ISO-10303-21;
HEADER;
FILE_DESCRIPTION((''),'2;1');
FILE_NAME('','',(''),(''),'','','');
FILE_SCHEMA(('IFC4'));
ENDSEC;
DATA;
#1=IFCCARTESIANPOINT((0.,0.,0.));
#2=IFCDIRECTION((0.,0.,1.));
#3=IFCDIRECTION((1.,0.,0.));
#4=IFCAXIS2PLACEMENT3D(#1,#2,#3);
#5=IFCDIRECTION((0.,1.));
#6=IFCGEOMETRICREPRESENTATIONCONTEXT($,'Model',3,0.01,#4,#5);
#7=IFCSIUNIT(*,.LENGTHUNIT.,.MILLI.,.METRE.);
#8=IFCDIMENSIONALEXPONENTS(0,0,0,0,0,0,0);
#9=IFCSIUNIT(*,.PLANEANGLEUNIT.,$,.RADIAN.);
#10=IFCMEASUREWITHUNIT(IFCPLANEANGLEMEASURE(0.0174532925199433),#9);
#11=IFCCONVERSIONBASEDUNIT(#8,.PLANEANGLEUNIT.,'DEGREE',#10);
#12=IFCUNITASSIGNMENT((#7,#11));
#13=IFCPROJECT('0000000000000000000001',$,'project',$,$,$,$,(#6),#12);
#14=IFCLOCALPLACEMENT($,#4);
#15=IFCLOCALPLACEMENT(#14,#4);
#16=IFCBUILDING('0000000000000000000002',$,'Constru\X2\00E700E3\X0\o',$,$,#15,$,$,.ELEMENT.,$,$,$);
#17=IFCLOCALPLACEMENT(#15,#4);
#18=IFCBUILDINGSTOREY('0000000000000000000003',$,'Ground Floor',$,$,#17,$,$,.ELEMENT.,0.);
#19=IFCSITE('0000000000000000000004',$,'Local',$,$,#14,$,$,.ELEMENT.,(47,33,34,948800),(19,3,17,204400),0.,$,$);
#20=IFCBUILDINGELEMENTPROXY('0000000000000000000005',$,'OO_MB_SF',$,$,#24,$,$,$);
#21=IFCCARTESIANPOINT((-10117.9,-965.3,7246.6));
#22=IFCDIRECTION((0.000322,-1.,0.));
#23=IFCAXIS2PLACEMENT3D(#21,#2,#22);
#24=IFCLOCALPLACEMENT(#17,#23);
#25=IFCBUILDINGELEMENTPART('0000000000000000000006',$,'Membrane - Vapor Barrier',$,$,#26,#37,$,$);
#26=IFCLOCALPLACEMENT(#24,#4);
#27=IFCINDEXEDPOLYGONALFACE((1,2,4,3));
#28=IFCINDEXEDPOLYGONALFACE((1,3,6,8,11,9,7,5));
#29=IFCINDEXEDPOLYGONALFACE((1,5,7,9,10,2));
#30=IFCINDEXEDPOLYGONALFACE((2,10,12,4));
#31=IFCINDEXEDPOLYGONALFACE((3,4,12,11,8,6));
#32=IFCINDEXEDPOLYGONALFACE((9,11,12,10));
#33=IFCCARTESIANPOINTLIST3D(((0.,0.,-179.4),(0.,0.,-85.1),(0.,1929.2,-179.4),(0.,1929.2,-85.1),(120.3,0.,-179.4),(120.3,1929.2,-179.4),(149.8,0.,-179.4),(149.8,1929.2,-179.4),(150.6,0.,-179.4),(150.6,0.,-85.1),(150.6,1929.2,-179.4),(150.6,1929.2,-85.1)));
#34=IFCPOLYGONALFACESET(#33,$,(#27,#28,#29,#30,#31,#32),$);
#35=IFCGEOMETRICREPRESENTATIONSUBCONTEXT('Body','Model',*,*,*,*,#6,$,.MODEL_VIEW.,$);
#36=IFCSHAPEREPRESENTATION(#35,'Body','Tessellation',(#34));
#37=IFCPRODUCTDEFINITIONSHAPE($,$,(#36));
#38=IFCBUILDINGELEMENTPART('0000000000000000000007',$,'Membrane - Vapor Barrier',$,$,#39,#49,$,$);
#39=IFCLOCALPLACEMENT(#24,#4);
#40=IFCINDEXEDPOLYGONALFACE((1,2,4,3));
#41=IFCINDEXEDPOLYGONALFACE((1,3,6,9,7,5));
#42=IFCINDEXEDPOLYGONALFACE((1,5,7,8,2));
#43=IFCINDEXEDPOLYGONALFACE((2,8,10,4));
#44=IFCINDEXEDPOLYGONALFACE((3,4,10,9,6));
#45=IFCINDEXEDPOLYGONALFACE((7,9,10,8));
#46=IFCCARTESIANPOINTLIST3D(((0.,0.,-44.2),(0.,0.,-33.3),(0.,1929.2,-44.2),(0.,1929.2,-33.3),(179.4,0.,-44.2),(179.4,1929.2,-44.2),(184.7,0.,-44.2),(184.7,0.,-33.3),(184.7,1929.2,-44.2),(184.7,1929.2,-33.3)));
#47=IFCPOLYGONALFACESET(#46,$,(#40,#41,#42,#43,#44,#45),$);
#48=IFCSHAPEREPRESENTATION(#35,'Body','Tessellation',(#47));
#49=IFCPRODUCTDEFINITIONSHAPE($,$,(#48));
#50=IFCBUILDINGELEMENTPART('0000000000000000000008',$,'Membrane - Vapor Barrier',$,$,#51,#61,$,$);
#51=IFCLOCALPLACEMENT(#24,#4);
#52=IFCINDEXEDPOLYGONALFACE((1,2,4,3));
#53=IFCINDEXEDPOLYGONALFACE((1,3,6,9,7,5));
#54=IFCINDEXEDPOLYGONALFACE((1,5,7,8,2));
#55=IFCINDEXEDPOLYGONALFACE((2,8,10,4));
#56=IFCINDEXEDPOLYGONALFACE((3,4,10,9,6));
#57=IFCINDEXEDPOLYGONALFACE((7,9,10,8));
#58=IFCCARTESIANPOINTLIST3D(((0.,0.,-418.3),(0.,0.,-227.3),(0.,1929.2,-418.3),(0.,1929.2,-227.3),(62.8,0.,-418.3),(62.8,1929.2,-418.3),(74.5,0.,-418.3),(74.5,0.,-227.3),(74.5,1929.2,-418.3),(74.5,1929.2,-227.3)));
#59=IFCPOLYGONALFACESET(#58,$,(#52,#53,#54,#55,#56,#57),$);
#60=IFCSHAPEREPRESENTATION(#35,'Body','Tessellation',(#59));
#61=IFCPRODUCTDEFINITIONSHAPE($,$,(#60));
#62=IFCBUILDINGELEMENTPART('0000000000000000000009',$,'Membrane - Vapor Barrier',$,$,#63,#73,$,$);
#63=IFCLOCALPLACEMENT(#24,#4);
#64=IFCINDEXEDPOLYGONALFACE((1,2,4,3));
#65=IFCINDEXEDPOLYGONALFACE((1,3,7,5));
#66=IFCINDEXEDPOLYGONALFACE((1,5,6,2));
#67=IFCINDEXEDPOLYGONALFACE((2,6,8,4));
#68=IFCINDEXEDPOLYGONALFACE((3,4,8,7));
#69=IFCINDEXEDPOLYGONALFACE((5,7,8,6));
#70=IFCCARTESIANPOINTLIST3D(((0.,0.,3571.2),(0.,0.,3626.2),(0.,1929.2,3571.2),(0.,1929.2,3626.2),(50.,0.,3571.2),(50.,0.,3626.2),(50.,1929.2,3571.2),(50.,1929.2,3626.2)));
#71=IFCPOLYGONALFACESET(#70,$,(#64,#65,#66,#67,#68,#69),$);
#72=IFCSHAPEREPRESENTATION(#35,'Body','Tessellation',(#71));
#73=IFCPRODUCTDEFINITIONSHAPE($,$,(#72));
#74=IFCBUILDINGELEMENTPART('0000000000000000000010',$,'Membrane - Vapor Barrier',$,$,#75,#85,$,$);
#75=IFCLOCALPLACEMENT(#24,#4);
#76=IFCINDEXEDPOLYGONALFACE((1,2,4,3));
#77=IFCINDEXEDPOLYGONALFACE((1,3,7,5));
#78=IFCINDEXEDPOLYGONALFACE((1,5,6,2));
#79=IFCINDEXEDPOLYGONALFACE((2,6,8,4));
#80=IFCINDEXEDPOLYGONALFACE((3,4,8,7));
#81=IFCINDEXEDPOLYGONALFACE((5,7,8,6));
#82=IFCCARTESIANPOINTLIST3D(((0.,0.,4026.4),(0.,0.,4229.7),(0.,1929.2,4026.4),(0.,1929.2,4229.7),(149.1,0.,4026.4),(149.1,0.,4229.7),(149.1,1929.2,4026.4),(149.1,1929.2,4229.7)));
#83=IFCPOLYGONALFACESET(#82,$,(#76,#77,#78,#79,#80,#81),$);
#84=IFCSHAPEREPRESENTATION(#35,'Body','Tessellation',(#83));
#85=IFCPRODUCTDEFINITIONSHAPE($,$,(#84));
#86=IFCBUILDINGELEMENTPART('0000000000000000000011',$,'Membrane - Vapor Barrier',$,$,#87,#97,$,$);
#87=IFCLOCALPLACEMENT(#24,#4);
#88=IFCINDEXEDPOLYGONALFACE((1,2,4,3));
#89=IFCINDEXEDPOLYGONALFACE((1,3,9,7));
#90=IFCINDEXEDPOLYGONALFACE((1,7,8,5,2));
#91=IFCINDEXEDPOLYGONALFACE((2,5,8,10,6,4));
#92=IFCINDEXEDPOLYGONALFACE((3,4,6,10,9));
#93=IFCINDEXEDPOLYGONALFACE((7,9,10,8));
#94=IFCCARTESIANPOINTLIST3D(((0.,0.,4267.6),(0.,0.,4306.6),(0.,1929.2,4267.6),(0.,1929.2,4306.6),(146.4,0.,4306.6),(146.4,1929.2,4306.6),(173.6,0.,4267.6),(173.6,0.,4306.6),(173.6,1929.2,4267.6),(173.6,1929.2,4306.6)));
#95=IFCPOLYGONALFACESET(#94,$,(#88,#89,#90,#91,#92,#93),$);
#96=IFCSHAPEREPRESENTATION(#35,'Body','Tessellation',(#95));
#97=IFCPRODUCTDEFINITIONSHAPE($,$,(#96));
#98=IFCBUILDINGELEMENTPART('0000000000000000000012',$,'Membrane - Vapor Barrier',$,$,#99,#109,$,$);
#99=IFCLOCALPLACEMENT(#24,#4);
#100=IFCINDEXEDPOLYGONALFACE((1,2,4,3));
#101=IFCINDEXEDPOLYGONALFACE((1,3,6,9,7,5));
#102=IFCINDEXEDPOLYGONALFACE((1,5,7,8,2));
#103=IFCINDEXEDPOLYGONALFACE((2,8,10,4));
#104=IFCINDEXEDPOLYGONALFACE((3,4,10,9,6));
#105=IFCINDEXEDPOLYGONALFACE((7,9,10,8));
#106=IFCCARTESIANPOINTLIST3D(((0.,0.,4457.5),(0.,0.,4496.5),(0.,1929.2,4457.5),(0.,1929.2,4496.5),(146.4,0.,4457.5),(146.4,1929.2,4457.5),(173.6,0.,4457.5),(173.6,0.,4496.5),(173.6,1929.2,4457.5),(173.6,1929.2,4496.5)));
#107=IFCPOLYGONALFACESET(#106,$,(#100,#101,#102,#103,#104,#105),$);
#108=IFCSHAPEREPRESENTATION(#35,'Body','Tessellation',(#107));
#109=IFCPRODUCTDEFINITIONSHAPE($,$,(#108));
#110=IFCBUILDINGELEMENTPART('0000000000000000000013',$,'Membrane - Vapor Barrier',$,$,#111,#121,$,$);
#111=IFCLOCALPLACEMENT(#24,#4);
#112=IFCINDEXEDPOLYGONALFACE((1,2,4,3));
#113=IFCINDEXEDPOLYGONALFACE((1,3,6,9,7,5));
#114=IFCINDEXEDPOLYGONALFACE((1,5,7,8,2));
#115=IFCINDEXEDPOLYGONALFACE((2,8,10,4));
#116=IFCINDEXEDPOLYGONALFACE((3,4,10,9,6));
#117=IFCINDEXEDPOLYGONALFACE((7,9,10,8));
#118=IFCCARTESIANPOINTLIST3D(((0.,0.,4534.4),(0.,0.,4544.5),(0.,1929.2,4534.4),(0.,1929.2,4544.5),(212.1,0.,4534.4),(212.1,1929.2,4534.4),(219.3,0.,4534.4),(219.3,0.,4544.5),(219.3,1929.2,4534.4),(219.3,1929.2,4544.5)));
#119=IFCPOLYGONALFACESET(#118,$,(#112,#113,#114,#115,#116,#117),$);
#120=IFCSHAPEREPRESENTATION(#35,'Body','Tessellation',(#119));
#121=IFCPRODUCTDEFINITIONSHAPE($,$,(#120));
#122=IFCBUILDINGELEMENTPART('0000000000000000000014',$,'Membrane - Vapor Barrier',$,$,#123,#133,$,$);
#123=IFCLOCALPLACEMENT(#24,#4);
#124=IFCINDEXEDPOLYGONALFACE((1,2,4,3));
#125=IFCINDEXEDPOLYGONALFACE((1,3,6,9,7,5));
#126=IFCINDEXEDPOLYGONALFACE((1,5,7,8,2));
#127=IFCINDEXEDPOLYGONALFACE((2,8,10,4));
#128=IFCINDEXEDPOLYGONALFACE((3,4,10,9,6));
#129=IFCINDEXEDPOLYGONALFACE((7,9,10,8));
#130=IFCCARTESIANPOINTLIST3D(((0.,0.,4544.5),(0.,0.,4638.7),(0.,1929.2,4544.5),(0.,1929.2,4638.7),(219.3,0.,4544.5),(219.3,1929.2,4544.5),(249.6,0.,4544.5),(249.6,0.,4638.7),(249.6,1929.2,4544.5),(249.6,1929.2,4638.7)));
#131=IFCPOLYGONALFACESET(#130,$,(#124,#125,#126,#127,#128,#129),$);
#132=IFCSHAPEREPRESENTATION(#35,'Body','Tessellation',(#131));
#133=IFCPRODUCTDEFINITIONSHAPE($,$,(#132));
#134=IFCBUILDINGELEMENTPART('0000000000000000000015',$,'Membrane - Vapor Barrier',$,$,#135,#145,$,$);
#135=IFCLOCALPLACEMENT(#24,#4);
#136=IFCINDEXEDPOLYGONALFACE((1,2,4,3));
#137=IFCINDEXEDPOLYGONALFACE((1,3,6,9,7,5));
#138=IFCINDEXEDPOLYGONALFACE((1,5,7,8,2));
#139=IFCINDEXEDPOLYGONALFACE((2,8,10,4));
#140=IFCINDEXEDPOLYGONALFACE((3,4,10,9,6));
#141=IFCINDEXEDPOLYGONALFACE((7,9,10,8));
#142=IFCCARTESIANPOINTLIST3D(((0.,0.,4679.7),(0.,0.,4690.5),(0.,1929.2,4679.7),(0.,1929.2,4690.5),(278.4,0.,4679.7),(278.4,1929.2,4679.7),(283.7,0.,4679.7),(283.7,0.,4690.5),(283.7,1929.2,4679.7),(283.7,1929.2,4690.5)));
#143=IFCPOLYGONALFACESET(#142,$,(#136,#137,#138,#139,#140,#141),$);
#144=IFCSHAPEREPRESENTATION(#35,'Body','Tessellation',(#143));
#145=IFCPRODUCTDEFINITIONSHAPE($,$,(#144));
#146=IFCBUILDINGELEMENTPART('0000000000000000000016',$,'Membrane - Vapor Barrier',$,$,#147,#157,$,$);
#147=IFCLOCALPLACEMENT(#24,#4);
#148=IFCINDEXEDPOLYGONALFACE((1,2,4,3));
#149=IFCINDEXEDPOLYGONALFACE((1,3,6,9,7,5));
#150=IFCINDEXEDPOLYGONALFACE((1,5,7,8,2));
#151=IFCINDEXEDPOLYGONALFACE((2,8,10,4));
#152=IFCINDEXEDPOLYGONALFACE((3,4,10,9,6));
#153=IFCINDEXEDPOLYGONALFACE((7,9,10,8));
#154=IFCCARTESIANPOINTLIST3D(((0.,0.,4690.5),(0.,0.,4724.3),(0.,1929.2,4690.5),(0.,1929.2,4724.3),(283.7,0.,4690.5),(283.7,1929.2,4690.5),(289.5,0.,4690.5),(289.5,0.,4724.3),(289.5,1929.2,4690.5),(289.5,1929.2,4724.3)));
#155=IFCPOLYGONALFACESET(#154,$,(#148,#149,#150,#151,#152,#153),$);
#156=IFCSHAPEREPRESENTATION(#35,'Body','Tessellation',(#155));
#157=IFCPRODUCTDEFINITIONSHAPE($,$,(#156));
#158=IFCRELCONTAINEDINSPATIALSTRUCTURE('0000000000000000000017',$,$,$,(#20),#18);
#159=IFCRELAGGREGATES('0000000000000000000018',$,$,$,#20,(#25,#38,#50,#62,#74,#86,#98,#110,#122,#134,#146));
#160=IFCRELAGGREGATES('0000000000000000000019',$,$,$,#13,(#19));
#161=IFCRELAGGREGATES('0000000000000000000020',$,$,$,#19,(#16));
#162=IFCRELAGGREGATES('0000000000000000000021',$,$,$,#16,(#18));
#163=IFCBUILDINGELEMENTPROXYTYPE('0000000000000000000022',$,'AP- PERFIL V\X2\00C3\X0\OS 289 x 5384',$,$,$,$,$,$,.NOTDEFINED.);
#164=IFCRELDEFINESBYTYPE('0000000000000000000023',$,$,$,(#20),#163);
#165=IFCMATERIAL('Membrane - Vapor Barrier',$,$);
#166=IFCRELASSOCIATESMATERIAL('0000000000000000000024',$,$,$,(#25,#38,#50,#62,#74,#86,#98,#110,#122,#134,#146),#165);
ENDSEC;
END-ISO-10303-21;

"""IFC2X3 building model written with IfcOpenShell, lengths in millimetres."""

from ifc_helpers import new_model, entity, si_unit, converted_unit, direction, frame, origin_with_axes, place, context, subcontext, project, spatial, polyline, outline, extrude, material, type_object, element, aggregate, save


model = new_model("IFC2X3")

# Units and contexts
model_context = context("Model", 3, precision=0.01, world=origin_with_axes(), true_north=direction((0.0, 1.0)))
body_context = subcontext(model_context, "Body", "Model", "MODEL_VIEW")
ifc_project = project(units=[si_unit("LENGTHUNIT", "METRE", prefix="MILLI"), converted_unit("PLANEANGLEUNIT", "DEGREE", entity("IfcPlaneAngleMeasure", 0.0174532925199433), si_unit("PLANEANGLEUNIT", "RADIAN"), dimensions=[0, 0, 0, 0, 0, 0, 0])], contexts=[model_context])

# Site, building, storey
site_placement = place(None, origin_with_axes())
site = spatial("IfcSite", under=ifc_project, at=site_placement, Name="Local", CompositionType="ELEMENT", RefLatitude=(47, 33, 34, 948800), RefLongitude=(19, 3, 17, 204400), RefElevation=0.0)
building_placement = place(site_placement, origin_with_axes())
building = spatial("IfcBuilding", under=site, at=building_placement, Name="Construção", CompositionType="ELEMENT")
storey_placement = place(building_placement, origin_with_axes())
storey = spatial("IfcBuildingStorey", under=building, at=storey_placement, Name="Ground Floor", CompositionType="ELEMENT", Elevation=0.0)

# Building element proxy, building element parts
building_element_proxy_type = type_object("IfcBuildingElementProxyType", Name="AP- PERFIL VÃOS 289 x 5384", PredefinedType="NOTDEFINED")
ifc_material = material(Name="Membrane - Vapor Barrier")
proxy_1_placement = place(storey_placement, frame((-10117.9, -965.3, 7246.6), z_axis=(0.0, 0.0, 1.0), x_axis=(0.000322, -1.0, 0.0)))
proxy_1 = element("IfcBuildingElementProxy", 1, at=proxy_1_placement, inside=storey, type_object=building_element_proxy_type, Name="OO_MB_SF")
building_element_part_1_placement = place(proxy_1_placement, origin_with_axes())
building_element_part_1 = element("IfcBuildingElementPart", 2, at=building_element_part_1_placement, material=ifc_material, Name="Membrane - Vapor Barrier", context=body_context, shape_type="SweptSolid", body=[
    extrude(outline(polyline([(0.0, -85.1), (0.0, -179.4), (120.3, -179.4), (149.8, -179.4), (150.6, -179.4), (150.6, -85.1), (0.0, -85.1)])), frame((0.0, 1929.2, 0.0), z_axis=(0.0, -1.0, 0.0), x_axis=(1.0, 0.0, 0.0)), (0.0, 0.0, 1.0), 1929.2),
])
building_element_part_2_placement = place(proxy_1_placement, origin_with_axes())
building_element_part_2 = element("IfcBuildingElementPart", 3, at=building_element_part_2_placement, material=ifc_material, Name="Membrane - Vapor Barrier", context=body_context, shape_type="SweptSolid", body=[
    extrude(outline(polyline([(184.7, -33.3), (0.0, -33.3), (0.0, -44.2), (179.4, -44.2), (184.7, -44.2), (184.7, -33.3)])), frame((0.0, 1929.2, 0.0), z_axis=(0.0, -1.0, 0.0), x_axis=(1.0, 0.0, 0.0)), (0.0, 0.0, 1.0), 1929.2),
])
building_element_part_3_placement = place(proxy_1_placement, origin_with_axes())
building_element_part_3 = element("IfcBuildingElementPart", 4, at=building_element_part_3_placement, material=ifc_material, Name="Membrane - Vapor Barrier", context=body_context, shape_type="SweptSolid", body=[
    extrude(outline(polyline([(0.0, -227.3), (0.0, -418.3), (62.8, -418.3), (74.5, -418.3), (74.5, -227.3), (0.0, -227.3)])), frame((0.0, 1929.2, 0.0), z_axis=(0.0, -1.0, 0.0), x_axis=(1.0, 0.0, 0.0)), (0.0, 0.0, 1.0), 1929.2),
])
building_element_part_4_placement = place(proxy_1_placement, origin_with_axes())
building_element_part_4 = element("IfcBuildingElementPart", 5, at=building_element_part_4_placement, material=ifc_material, Name="Membrane - Vapor Barrier", context=body_context, shape_type="SweptSolid", body=[
    extrude(outline(polyline([(0.0, 3571.2), (50.0, 3571.2), (50.0, 3626.2), (0.0, 3626.2), (0.0, 3571.2)])), frame((0.0, 1929.2, 0.0), z_axis=(0.0, -1.0, 0.0), x_axis=(1.0, 0.0, 0.0)), (0.0, 0.0, 1.0), 1929.2),
])
building_element_part_5_placement = place(proxy_1_placement, origin_with_axes())
building_element_part_5 = element("IfcBuildingElementPart", 6, at=building_element_part_5_placement, material=ifc_material, Name="Membrane - Vapor Barrier", context=body_context, shape_type="SweptSolid", body=[
    extrude(outline(polyline([(149.1, 4229.7), (0.0, 4229.7), (0.0, 4026.4), (149.1, 4026.4), (149.1, 4229.7)])), frame((0.0, 1929.2, 0.0), z_axis=(0.0, -1.0, 0.0), x_axis=(1.0, 0.0, 0.0)), (0.0, 0.0, 1.0), 1929.2),
])
building_element_part_6_placement = place(proxy_1_placement, origin_with_axes())
building_element_part_6 = element("IfcBuildingElementPart", 7, at=building_element_part_6_placement, material=ifc_material, Name="Membrane - Vapor Barrier", context=body_context, shape_type="SweptSolid", body=[
    extrude(outline(polyline([(0.0, 4306.6), (0.0, 4267.6), (173.6, 4267.6), (173.6, 4306.6), (146.4, 4306.6), (0.0, 4306.6)])), frame((0.0, 1929.2, 0.0), z_axis=(0.0, -1.0, 0.0), x_axis=(1.0, 0.0, 0.0)), (0.0, 0.0, 1.0), 1929.2),
])
building_element_part_7_placement = place(proxy_1_placement, origin_with_axes())
building_element_part_7 = element("IfcBuildingElementPart", 8, at=building_element_part_7_placement, material=ifc_material, Name="Membrane - Vapor Barrier", context=body_context, shape_type="SweptSolid", body=[
    extrude(outline(polyline([(173.6, 4496.5), (0.0, 4496.5), (0.0, 4457.5), (146.4, 4457.5), (173.6, 4457.5), (173.6, 4496.5)])), frame((0.0, 1929.2, 0.0), z_axis=(0.0, -1.0, 0.0), x_axis=(1.0, 0.0, 0.0)), (0.0, 0.0, 1.0), 1929.2),
])
building_element_part_8_placement = place(proxy_1_placement, origin_with_axes())
building_element_part_8 = element("IfcBuildingElementPart", 9, at=building_element_part_8_placement, material=ifc_material, Name="Membrane - Vapor Barrier", context=body_context, shape_type="SweptSolid", body=[
    extrude(outline(polyline([(0.0, 4534.4), (212.1, 4534.4), (219.3, 4534.4), (219.3, 4544.5), (0.0, 4544.5), (0.0, 4534.4)])), frame((0.0, 1929.2, 0.0), z_axis=(0.0, -1.0, 0.0), x_axis=(1.0, 0.0, 0.0)), (0.0, 0.0, 1.0), 1929.2),
])
building_element_part_9_placement = place(proxy_1_placement, origin_with_axes())
building_element_part_9 = element("IfcBuildingElementPart", 10, at=building_element_part_9_placement, material=ifc_material, Name="Membrane - Vapor Barrier", context=body_context, shape_type="SweptSolid", body=[
    extrude(outline(polyline([(249.6, 4638.7), (0.0, 4638.7), (0.0, 4544.5), (219.3, 4544.5), (249.6, 4544.5), (249.6, 4638.7)])), frame((0.0, 1929.2, 0.0), z_axis=(0.0, -1.0, 0.0), x_axis=(1.0, 0.0, 0.0)), (0.0, 0.0, 1.0), 1929.2),
])
building_element_part_10_placement = place(proxy_1_placement, origin_with_axes())
building_element_part_10 = element("IfcBuildingElementPart", 11, at=building_element_part_10_placement, material=ifc_material, Name="Membrane - Vapor Barrier", context=body_context, shape_type="SweptSolid", body=[
    extrude(outline(polyline([(0.0, 4679.7), (278.4, 4679.7), (283.7, 4679.7), (283.7, 4690.5), (0.0, 4690.5), (0.0, 4679.7)])), frame((0.0, 1929.2, 0.0), z_axis=(0.0, -1.0, 0.0), x_axis=(1.0, 0.0, 0.0)), (0.0, 0.0, 1.0), 1929.2),
])
building_element_part_11_placement = place(proxy_1_placement, origin_with_axes())
building_element_part_11 = element("IfcBuildingElementPart", 12, at=building_element_part_11_placement, material=ifc_material, Name="Membrane - Vapor Barrier", context=body_context, shape_type="SweptSolid", body=[
    extrude(outline(polyline([(0.0, 4690.5), (283.7, 4690.5), (289.5, 4690.5), (289.5, 4724.3), (0.0, 4724.3), (0.0, 4690.5)])), frame((0.0, 1929.2, 0.0), z_axis=(0.0, -1.0, 0.0), x_axis=(1.0, 0.0, 0.0)), (0.0, 0.0, 1.0), 1929.2),
])
aggregate(proxy_1, [building_element_part_1, building_element_part_2, building_element_part_3, building_element_part_4, building_element_part_5, building_element_part_6, building_element_part_7, building_element_part_8, building_element_part_9, building_element_part_10, building_element_part_11])

save(model, "model.ifc")
